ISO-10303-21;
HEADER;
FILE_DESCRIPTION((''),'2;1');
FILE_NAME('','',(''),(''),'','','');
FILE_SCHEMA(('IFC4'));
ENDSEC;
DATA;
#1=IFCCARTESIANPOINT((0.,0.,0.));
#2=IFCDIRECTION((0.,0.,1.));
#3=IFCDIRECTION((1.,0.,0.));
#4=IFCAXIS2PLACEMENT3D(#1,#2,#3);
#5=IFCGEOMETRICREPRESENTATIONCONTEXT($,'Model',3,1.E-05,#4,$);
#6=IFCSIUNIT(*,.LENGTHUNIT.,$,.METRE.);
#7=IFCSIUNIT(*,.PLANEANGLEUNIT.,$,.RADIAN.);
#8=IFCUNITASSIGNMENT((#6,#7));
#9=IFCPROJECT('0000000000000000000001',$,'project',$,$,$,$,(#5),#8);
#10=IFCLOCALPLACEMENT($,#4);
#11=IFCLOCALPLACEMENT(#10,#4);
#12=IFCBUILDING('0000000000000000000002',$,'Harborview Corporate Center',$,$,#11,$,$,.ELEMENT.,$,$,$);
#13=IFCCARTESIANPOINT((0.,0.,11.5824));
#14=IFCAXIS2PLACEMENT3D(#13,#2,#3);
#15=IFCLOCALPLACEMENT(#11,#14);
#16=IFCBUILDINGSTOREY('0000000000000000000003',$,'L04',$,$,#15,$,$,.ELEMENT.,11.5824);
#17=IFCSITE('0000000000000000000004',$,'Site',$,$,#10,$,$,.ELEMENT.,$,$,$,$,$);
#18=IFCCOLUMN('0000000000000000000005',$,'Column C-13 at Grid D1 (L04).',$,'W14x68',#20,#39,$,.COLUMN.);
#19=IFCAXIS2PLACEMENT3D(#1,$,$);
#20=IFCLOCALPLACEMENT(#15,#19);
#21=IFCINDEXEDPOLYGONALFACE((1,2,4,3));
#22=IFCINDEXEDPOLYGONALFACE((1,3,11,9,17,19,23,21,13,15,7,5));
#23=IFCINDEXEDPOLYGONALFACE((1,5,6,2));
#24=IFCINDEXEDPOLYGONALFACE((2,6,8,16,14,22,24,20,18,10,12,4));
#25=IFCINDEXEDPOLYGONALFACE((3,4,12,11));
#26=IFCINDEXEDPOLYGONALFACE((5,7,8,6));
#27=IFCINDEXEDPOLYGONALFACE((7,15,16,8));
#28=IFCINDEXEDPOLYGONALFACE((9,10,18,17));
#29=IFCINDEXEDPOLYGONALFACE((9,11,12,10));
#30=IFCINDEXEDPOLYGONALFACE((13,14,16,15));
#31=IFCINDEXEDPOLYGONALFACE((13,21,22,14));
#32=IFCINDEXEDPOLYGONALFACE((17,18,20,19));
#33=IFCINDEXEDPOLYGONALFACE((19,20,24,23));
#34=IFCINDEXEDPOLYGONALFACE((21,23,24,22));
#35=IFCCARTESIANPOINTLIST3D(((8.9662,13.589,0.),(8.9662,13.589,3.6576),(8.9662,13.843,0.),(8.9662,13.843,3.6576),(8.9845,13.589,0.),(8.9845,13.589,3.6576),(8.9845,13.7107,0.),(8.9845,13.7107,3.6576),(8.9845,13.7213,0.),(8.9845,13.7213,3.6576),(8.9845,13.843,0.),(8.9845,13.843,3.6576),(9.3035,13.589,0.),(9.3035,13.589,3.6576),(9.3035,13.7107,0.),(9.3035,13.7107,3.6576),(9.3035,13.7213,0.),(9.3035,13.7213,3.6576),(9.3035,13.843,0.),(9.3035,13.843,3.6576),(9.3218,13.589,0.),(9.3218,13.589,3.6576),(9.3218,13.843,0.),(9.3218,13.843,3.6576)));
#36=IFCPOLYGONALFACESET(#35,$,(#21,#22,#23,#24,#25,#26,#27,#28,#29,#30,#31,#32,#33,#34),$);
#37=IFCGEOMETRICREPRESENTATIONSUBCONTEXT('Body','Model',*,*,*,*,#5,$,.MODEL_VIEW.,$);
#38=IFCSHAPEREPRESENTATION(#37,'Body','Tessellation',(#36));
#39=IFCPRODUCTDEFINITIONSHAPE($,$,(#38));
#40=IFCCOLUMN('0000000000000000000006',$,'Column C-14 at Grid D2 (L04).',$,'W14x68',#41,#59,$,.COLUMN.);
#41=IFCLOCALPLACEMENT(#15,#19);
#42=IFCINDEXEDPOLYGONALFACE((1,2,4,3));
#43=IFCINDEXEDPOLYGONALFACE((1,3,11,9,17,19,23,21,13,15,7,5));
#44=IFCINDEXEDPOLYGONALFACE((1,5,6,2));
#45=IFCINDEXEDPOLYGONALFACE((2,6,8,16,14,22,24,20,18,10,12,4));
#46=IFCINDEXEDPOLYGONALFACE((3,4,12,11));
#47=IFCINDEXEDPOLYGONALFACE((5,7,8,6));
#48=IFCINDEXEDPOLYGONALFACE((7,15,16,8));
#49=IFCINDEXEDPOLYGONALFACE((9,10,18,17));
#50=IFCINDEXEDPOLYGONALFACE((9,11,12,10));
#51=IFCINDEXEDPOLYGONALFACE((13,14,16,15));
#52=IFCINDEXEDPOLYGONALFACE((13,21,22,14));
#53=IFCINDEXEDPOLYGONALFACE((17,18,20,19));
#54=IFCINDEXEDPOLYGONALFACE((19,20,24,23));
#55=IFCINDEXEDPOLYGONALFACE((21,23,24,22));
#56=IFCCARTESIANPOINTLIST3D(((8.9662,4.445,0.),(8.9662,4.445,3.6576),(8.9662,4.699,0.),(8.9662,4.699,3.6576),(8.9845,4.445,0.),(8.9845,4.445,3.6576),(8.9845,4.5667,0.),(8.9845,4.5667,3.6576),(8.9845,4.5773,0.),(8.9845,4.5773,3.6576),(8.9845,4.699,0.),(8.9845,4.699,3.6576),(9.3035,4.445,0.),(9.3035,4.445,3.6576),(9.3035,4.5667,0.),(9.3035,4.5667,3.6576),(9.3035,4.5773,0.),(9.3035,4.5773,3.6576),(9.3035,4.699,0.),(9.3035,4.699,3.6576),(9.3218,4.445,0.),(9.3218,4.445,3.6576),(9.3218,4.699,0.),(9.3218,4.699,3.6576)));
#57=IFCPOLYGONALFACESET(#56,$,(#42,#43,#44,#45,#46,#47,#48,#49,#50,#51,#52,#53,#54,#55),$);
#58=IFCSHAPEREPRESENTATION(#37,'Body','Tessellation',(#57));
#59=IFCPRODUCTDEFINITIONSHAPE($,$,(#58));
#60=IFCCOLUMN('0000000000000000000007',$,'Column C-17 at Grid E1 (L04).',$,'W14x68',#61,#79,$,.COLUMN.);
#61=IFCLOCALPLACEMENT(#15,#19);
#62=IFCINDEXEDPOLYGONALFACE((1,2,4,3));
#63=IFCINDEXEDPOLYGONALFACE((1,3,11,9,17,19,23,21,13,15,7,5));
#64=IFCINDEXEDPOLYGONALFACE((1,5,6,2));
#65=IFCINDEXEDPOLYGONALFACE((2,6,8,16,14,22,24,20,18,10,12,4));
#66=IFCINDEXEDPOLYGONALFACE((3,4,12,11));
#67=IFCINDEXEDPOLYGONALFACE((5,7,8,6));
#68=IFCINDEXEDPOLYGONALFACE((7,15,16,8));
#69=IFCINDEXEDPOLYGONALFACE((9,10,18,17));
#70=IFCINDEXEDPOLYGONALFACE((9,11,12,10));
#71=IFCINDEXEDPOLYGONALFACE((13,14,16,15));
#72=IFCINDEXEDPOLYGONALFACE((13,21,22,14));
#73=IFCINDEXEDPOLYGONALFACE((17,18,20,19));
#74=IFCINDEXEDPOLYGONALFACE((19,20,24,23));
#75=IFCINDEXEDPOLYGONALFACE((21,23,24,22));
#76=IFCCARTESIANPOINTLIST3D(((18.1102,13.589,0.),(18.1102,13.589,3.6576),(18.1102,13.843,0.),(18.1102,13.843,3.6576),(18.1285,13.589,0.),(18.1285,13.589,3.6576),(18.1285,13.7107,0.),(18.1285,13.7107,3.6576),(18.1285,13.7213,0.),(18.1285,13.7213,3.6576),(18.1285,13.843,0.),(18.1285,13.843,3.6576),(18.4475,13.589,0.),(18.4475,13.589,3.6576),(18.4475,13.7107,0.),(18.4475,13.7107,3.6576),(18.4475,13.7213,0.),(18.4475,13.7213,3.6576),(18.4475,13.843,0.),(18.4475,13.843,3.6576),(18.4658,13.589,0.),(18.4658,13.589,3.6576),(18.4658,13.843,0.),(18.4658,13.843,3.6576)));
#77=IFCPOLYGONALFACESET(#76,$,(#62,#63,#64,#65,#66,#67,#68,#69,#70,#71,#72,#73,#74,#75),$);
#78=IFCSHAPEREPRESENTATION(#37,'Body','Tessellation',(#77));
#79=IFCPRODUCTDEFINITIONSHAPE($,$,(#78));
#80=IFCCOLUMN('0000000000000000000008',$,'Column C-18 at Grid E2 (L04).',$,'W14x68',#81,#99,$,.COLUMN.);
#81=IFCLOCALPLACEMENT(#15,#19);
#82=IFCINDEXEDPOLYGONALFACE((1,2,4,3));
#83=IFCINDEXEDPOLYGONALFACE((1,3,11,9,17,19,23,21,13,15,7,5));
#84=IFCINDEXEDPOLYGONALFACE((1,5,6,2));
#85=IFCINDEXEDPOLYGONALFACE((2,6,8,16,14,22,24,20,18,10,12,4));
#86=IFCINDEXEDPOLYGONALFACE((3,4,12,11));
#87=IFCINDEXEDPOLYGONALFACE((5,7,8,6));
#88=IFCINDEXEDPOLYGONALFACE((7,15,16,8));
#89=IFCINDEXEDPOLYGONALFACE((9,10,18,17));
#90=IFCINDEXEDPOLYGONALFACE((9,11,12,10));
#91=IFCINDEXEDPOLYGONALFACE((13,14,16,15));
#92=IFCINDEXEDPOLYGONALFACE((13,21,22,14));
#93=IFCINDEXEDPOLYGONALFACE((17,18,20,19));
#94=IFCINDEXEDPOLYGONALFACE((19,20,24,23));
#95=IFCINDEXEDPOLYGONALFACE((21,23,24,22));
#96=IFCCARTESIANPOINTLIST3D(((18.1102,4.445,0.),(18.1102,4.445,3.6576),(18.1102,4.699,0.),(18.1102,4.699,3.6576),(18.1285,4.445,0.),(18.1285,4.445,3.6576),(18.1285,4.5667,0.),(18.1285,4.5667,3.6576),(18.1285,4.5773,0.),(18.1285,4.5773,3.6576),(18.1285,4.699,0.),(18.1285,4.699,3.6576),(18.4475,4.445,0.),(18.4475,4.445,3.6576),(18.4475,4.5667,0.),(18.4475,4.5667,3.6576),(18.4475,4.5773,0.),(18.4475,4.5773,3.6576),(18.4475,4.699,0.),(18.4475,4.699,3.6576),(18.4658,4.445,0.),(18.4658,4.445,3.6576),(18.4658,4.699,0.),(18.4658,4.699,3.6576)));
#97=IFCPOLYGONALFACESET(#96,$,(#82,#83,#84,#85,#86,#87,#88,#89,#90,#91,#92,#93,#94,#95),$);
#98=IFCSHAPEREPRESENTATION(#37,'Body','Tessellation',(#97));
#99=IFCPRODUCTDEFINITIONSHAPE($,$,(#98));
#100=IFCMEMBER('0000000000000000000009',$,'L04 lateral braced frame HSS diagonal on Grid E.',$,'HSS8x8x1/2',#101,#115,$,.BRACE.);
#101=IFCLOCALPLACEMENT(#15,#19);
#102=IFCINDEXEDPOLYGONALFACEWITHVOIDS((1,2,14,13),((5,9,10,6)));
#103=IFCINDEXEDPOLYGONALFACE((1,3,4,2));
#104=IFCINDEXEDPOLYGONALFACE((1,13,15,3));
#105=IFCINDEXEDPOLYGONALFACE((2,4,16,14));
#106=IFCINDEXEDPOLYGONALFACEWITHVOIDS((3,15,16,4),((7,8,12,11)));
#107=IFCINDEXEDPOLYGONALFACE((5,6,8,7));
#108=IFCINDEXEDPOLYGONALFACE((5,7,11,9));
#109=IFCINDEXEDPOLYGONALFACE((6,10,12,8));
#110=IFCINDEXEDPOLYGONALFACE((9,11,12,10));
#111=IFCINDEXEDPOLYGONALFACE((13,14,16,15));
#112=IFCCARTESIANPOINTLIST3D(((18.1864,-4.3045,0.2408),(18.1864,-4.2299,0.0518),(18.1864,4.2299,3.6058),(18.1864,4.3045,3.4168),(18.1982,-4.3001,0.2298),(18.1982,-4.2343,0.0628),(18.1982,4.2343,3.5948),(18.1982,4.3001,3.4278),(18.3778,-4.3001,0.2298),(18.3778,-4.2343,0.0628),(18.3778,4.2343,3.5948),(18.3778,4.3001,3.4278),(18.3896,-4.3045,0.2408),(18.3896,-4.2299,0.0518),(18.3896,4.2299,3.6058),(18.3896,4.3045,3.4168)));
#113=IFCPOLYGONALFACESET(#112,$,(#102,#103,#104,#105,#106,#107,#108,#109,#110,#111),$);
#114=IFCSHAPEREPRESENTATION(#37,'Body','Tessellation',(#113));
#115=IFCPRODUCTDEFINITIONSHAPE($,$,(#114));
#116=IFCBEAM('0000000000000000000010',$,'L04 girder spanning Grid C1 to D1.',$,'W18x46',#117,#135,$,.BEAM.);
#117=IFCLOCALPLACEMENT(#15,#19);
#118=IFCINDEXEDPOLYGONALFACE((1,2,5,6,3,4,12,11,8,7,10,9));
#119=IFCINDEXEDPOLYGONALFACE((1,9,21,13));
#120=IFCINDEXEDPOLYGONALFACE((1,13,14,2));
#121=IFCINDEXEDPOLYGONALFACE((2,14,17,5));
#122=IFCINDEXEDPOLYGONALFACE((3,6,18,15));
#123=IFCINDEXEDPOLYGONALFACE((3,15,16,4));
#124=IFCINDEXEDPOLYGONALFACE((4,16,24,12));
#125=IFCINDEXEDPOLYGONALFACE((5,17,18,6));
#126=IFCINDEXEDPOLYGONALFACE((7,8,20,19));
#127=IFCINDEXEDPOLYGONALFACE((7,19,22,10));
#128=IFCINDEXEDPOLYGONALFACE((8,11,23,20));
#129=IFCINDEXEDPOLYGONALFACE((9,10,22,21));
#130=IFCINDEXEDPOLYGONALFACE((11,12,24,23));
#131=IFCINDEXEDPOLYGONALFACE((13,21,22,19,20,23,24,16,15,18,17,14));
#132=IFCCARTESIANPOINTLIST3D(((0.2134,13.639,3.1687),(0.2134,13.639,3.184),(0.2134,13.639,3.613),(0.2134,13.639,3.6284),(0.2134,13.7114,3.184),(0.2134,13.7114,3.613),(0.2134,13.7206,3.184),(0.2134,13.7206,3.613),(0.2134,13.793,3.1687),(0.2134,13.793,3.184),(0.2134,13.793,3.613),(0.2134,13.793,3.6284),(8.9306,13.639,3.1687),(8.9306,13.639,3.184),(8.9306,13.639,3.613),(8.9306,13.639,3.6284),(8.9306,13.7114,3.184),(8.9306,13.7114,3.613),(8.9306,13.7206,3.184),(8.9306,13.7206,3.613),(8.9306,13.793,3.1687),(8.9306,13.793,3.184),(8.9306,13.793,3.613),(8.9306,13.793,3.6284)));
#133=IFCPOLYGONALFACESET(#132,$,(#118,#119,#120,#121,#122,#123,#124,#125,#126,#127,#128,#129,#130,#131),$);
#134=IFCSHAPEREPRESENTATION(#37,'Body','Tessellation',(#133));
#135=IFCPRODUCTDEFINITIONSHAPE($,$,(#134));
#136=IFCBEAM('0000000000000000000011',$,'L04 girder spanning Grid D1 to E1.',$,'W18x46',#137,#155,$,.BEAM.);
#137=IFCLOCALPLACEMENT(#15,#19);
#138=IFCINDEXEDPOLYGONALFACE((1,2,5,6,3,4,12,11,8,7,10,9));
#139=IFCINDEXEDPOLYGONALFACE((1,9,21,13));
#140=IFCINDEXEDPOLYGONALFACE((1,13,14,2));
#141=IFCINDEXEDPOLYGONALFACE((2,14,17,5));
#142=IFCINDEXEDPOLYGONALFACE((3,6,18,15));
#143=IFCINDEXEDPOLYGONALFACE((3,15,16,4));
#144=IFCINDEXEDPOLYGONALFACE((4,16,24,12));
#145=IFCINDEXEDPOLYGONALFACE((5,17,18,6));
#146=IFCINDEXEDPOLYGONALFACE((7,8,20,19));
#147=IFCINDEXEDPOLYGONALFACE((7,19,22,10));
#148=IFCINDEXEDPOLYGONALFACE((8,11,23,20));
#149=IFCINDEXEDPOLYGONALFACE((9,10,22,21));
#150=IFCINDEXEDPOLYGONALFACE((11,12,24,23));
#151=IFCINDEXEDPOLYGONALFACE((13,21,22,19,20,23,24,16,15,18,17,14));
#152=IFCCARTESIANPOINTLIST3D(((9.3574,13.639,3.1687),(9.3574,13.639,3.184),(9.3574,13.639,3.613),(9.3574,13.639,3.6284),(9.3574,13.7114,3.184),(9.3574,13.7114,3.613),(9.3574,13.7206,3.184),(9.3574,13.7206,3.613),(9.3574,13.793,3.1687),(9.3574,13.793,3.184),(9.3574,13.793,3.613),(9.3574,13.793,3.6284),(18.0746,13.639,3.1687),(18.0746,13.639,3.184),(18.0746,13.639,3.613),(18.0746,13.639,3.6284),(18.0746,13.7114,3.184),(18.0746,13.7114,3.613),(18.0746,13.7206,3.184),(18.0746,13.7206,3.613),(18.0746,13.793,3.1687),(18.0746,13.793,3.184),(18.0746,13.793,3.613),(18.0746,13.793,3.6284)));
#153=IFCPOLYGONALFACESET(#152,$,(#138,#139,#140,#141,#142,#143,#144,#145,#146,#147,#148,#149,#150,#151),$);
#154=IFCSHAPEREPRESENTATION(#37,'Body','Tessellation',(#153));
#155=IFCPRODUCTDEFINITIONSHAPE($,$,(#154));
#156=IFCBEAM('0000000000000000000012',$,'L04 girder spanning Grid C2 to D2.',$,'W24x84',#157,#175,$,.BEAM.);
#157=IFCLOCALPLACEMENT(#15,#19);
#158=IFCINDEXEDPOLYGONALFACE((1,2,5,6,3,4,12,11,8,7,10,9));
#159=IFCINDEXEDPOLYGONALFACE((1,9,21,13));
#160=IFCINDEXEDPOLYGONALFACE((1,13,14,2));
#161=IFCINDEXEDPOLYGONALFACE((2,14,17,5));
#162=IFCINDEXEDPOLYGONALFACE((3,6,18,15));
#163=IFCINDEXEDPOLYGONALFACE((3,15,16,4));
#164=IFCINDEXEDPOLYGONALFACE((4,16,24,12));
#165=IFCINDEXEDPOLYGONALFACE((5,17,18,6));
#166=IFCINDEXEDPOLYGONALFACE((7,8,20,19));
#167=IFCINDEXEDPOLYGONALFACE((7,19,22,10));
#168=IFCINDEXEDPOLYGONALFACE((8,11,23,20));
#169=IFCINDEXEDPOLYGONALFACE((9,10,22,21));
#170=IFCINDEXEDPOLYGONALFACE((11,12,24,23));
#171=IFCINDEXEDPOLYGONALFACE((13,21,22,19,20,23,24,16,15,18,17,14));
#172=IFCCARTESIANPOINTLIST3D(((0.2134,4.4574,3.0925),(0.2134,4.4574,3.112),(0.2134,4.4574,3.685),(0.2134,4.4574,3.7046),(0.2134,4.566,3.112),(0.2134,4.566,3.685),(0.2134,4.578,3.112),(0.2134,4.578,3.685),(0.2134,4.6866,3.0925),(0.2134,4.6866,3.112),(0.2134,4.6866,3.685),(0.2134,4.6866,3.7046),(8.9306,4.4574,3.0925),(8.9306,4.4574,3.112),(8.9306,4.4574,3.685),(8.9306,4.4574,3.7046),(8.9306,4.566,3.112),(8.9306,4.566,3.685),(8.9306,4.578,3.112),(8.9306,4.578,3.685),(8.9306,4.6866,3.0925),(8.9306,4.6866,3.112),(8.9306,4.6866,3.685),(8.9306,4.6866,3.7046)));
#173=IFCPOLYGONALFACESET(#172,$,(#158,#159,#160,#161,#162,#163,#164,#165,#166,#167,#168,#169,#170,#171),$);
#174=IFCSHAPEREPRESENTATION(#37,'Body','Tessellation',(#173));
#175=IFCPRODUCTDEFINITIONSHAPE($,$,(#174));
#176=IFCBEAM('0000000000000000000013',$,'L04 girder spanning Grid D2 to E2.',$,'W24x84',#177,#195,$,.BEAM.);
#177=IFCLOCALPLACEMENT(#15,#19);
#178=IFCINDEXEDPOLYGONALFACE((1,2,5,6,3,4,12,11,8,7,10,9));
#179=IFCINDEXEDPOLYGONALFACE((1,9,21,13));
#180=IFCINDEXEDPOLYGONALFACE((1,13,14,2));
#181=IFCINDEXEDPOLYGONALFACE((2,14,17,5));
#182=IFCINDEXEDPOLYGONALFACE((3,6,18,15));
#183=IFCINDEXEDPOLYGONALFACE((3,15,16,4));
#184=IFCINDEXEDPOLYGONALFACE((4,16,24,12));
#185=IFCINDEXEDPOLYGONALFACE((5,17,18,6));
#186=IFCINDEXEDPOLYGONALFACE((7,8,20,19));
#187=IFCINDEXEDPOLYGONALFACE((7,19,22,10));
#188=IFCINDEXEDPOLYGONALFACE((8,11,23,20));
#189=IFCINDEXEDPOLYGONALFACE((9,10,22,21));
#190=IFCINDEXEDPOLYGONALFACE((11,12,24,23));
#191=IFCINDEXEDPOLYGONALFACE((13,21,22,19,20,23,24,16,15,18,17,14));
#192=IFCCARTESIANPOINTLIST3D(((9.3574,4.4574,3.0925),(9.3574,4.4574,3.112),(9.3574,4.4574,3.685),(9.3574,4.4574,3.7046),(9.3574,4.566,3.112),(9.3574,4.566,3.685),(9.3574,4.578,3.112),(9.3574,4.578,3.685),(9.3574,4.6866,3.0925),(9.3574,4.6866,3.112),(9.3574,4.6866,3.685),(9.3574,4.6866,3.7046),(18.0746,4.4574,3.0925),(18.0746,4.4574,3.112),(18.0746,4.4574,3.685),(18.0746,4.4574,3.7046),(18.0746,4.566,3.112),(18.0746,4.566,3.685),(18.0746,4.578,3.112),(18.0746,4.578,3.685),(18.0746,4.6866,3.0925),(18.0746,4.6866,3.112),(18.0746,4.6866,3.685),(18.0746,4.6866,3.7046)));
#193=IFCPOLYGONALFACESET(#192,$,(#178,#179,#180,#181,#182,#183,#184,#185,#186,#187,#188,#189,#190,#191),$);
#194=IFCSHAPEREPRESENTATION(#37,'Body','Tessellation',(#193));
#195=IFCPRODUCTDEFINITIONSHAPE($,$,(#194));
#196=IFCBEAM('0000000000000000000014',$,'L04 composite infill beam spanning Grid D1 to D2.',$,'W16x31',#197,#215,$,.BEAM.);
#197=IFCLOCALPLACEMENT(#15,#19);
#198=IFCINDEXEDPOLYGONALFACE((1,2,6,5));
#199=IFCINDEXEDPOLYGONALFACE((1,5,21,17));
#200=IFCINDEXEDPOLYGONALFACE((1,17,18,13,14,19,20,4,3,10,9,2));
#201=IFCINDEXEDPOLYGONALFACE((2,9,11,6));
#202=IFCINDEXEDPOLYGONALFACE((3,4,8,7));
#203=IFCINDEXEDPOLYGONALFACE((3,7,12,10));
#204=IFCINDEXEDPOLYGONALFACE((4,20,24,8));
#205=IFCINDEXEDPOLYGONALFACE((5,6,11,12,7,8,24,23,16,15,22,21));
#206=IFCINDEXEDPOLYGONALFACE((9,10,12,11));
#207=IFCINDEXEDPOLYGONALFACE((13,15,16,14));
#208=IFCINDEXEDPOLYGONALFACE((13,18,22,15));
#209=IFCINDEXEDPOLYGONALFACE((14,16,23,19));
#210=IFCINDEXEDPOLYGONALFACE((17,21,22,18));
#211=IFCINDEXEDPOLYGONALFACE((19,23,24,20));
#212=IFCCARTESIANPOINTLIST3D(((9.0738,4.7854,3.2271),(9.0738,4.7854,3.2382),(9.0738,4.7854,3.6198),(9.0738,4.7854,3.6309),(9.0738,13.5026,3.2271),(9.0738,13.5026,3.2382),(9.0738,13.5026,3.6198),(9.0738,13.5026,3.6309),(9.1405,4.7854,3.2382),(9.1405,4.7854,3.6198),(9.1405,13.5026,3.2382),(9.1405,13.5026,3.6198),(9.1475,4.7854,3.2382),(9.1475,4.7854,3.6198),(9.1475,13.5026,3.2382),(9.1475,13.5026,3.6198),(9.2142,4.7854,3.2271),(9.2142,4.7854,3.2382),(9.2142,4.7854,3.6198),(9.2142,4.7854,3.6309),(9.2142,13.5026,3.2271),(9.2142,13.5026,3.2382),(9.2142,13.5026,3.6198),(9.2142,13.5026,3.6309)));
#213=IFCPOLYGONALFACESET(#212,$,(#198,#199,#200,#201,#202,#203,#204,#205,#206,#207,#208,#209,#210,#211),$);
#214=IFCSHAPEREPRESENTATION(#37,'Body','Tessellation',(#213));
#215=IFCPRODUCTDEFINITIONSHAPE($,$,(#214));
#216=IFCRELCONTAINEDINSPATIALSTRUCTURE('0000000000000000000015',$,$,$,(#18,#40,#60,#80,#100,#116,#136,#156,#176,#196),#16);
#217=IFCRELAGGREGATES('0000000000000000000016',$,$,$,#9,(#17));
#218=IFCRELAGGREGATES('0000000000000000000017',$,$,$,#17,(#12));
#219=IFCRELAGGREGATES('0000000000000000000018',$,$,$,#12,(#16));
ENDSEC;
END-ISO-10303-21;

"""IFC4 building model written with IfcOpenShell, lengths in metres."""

from ifc_helpers import new_model, si_unit, frame, origin_with_axes, place, context, subcontext, project, spatial, hollow_rectangle, i_section, extrude, element, save


model = new_model("IFC4")

# Units and contexts
model_context = context("Model", 3, precision=1e-05, world=origin_with_axes())
body_context = subcontext(model_context, "Body", "Model", "MODEL_VIEW")
ifc_project = project(units=[si_unit("LENGTHUNIT", "METRE"), si_unit("PLANEANGLEUNIT", "RADIAN")], contexts=[model_context])

# Site, building, storey
site_placement = place(None, origin_with_axes())
site = spatial("IfcSite", under=ifc_project, at=site_placement, Name="Site", CompositionType="ELEMENT")
building_placement = place(site_placement, origin_with_axes())
building = spatial("IfcBuilding", under=site, at=building_placement, Name="Harborview Corporate Center", CompositionType="ELEMENT")
storey_placement = place(building_placement, frame((0.0, 0.0, 11.5824), z_axis=(0.0, 0.0, 1.0), x_axis=(1.0, 0.0, 0.0)))
storey = spatial("IfcBuildingStorey", under=building, at=storey_placement, Name="L04", CompositionType="ELEMENT", Elevation=11.5824)

# Columns
for number, where, z_axis, x_axis, name in (
    (1, (9.144, 13.716, 0.0), (0.0, 0.0, 1.0), (0.0, 1.0, 0.0), "Column C-13 at Grid D1 (L04)."),
    (2, (9.144, 4.572, 0.0), (0.0, 0.0, 1.0), (0.0, 1.0, 0.0), "Column C-14 at Grid D2 (L04)."),
    (3, (18.288, 13.716, 0.0), (0.0, 0.0, 1.0), (0.0, 1.0, 0.0), "Column C-17 at Grid E1 (L04)."),
    (4, (18.288, 4.572, 0.0), (0.0, 0.0, 1.0), (0.0, 1.0, 0.0), "Column C-18 at Grid E2 (L04)."),
):
    element("IfcColumn", number, at=place(storey_placement, frame(where, z_axis=z_axis, x_axis=x_axis)), inside=storey, Name=name, ObjectType="W14x68", PredefinedType="COLUMN", context=body_context, shape_type="SweptSolid", body=[
        extrude(i_section(OverallWidth=0.254, OverallDepth=0.3556, WebThickness=0.0105, FlangeThickness=0.0183), origin_with_axes(), (0.0, 0.0, 1.0), 3.6576),
    ])

# Member
member_placement = place(storey_placement, frame((18.288, -4.2672, 0.1463), z_axis=(0.0, 0.930298, 0.366803), x_axis=(-1.0, 0.0, 0.0)))
element("IfcMember", 5, at=member_placement, inside=storey, Name="L04 lateral braced frame HSS diagonal on Grid E.", ObjectType="HSS8x8x1/2", PredefinedType="BRACE", context=body_context, shape_type="SweptSolid", body=[
    extrude(hollow_rectangle(XDim=0.2032, YDim=0.2032, WallThickness=0.0118), origin_with_axes(), (0.0, 0.0, 1.0), 9.1738),
])

# Beams
beam_1_placement = place(storey_placement, frame((0.2134, 13.716, 3.3985), z_axis=(1.0, 0.0, 0.0), x_axis=(0.0, 1.0, 0.0)))
element("IfcBeam", 6, at=beam_1_placement, inside=storey, Name="L04 girder spanning Grid C1 to D1.", ObjectType="W18x46", PredefinedType="BEAM", context=body_context, shape_type="SweptSolid", body=[
    extrude(i_section(OverallWidth=0.1539, OverallDepth=0.4597, WebThickness=0.0091, FlangeThickness=0.0154), origin_with_axes(), (0.0, 0.0, 1.0), 8.7173),
])
beam_2_placement = place(storey_placement, frame((9.3574, 13.716, 3.3985), z_axis=(1.0, 0.0, 0.0), x_axis=(0.0, 1.0, 0.0)))
element("IfcBeam", 7, at=beam_2_placement, inside=storey, Name="L04 girder spanning Grid D1 to E1.", ObjectType="W18x46", PredefinedType="BEAM", context=body_context, shape_type="SweptSolid", body=[
    extrude(i_section(OverallWidth=0.1539, OverallDepth=0.4597, WebThickness=0.0091, FlangeThickness=0.0154), origin_with_axes(), (0.0, 0.0, 1.0), 8.7173),
])
beam_3_placement = place(storey_placement, frame((0.2134, 4.572, 3.3985), z_axis=(1.0, 0.0, 0.0), x_axis=(0.0, 1.0, 0.0)))
element("IfcBeam", 8, at=beam_3_placement, inside=storey, Name="L04 girder spanning Grid C2 to D2.", ObjectType="W24x84", PredefinedType="BEAM", context=body_context, shape_type="SweptSolid", body=[
    extrude(i_section(OverallWidth=0.2291, OverallDepth=0.6121, WebThickness=0.0119, FlangeThickness=0.0196), origin_with_axes(), (0.0, 0.0, 1.0), 8.7173),
])
beam_4_placement = place(storey_placement, frame((9.3574, 4.572, 3.3985), z_axis=(1.0, 0.0, 0.0), x_axis=(0.0, 1.0, 0.0)))
element("IfcBeam", 9, at=beam_4_placement, inside=storey, Name="L04 girder spanning Grid D2 to E2.", ObjectType="W24x84", PredefinedType="BEAM", context=body_context, shape_type="SweptSolid", body=[
    extrude(i_section(OverallWidth=0.2291, OverallDepth=0.6121, WebThickness=0.0119, FlangeThickness=0.0196), origin_with_axes(), (0.0, 0.0, 1.0), 8.7173),
])
for number, where, z_axis, x_axis, name in (
    (10, (9.144, 4.7854, 3.429), (0.0, 1.0, 0.0), (-1.0, 0.0, 0.0), "L04 composite infill beam spanning Grid D1 to D2."),
):
    element("IfcBeam", number, at=place(storey_placement, frame(where, z_axis=z_axis, x_axis=x_axis)), inside=storey, Name=name, ObjectType="W16x31", PredefinedType="BEAM", context=body_context, shape_type="SweptSolid", body=[
        extrude(i_section(OverallWidth=0.1405, OverallDepth=0.4039, WebThickness=0.007, FlangeThickness=0.0112), origin_with_axes(), (0.0, 0.0, 1.0), 8.7173),
    ])

save(model, "model.ifc")
